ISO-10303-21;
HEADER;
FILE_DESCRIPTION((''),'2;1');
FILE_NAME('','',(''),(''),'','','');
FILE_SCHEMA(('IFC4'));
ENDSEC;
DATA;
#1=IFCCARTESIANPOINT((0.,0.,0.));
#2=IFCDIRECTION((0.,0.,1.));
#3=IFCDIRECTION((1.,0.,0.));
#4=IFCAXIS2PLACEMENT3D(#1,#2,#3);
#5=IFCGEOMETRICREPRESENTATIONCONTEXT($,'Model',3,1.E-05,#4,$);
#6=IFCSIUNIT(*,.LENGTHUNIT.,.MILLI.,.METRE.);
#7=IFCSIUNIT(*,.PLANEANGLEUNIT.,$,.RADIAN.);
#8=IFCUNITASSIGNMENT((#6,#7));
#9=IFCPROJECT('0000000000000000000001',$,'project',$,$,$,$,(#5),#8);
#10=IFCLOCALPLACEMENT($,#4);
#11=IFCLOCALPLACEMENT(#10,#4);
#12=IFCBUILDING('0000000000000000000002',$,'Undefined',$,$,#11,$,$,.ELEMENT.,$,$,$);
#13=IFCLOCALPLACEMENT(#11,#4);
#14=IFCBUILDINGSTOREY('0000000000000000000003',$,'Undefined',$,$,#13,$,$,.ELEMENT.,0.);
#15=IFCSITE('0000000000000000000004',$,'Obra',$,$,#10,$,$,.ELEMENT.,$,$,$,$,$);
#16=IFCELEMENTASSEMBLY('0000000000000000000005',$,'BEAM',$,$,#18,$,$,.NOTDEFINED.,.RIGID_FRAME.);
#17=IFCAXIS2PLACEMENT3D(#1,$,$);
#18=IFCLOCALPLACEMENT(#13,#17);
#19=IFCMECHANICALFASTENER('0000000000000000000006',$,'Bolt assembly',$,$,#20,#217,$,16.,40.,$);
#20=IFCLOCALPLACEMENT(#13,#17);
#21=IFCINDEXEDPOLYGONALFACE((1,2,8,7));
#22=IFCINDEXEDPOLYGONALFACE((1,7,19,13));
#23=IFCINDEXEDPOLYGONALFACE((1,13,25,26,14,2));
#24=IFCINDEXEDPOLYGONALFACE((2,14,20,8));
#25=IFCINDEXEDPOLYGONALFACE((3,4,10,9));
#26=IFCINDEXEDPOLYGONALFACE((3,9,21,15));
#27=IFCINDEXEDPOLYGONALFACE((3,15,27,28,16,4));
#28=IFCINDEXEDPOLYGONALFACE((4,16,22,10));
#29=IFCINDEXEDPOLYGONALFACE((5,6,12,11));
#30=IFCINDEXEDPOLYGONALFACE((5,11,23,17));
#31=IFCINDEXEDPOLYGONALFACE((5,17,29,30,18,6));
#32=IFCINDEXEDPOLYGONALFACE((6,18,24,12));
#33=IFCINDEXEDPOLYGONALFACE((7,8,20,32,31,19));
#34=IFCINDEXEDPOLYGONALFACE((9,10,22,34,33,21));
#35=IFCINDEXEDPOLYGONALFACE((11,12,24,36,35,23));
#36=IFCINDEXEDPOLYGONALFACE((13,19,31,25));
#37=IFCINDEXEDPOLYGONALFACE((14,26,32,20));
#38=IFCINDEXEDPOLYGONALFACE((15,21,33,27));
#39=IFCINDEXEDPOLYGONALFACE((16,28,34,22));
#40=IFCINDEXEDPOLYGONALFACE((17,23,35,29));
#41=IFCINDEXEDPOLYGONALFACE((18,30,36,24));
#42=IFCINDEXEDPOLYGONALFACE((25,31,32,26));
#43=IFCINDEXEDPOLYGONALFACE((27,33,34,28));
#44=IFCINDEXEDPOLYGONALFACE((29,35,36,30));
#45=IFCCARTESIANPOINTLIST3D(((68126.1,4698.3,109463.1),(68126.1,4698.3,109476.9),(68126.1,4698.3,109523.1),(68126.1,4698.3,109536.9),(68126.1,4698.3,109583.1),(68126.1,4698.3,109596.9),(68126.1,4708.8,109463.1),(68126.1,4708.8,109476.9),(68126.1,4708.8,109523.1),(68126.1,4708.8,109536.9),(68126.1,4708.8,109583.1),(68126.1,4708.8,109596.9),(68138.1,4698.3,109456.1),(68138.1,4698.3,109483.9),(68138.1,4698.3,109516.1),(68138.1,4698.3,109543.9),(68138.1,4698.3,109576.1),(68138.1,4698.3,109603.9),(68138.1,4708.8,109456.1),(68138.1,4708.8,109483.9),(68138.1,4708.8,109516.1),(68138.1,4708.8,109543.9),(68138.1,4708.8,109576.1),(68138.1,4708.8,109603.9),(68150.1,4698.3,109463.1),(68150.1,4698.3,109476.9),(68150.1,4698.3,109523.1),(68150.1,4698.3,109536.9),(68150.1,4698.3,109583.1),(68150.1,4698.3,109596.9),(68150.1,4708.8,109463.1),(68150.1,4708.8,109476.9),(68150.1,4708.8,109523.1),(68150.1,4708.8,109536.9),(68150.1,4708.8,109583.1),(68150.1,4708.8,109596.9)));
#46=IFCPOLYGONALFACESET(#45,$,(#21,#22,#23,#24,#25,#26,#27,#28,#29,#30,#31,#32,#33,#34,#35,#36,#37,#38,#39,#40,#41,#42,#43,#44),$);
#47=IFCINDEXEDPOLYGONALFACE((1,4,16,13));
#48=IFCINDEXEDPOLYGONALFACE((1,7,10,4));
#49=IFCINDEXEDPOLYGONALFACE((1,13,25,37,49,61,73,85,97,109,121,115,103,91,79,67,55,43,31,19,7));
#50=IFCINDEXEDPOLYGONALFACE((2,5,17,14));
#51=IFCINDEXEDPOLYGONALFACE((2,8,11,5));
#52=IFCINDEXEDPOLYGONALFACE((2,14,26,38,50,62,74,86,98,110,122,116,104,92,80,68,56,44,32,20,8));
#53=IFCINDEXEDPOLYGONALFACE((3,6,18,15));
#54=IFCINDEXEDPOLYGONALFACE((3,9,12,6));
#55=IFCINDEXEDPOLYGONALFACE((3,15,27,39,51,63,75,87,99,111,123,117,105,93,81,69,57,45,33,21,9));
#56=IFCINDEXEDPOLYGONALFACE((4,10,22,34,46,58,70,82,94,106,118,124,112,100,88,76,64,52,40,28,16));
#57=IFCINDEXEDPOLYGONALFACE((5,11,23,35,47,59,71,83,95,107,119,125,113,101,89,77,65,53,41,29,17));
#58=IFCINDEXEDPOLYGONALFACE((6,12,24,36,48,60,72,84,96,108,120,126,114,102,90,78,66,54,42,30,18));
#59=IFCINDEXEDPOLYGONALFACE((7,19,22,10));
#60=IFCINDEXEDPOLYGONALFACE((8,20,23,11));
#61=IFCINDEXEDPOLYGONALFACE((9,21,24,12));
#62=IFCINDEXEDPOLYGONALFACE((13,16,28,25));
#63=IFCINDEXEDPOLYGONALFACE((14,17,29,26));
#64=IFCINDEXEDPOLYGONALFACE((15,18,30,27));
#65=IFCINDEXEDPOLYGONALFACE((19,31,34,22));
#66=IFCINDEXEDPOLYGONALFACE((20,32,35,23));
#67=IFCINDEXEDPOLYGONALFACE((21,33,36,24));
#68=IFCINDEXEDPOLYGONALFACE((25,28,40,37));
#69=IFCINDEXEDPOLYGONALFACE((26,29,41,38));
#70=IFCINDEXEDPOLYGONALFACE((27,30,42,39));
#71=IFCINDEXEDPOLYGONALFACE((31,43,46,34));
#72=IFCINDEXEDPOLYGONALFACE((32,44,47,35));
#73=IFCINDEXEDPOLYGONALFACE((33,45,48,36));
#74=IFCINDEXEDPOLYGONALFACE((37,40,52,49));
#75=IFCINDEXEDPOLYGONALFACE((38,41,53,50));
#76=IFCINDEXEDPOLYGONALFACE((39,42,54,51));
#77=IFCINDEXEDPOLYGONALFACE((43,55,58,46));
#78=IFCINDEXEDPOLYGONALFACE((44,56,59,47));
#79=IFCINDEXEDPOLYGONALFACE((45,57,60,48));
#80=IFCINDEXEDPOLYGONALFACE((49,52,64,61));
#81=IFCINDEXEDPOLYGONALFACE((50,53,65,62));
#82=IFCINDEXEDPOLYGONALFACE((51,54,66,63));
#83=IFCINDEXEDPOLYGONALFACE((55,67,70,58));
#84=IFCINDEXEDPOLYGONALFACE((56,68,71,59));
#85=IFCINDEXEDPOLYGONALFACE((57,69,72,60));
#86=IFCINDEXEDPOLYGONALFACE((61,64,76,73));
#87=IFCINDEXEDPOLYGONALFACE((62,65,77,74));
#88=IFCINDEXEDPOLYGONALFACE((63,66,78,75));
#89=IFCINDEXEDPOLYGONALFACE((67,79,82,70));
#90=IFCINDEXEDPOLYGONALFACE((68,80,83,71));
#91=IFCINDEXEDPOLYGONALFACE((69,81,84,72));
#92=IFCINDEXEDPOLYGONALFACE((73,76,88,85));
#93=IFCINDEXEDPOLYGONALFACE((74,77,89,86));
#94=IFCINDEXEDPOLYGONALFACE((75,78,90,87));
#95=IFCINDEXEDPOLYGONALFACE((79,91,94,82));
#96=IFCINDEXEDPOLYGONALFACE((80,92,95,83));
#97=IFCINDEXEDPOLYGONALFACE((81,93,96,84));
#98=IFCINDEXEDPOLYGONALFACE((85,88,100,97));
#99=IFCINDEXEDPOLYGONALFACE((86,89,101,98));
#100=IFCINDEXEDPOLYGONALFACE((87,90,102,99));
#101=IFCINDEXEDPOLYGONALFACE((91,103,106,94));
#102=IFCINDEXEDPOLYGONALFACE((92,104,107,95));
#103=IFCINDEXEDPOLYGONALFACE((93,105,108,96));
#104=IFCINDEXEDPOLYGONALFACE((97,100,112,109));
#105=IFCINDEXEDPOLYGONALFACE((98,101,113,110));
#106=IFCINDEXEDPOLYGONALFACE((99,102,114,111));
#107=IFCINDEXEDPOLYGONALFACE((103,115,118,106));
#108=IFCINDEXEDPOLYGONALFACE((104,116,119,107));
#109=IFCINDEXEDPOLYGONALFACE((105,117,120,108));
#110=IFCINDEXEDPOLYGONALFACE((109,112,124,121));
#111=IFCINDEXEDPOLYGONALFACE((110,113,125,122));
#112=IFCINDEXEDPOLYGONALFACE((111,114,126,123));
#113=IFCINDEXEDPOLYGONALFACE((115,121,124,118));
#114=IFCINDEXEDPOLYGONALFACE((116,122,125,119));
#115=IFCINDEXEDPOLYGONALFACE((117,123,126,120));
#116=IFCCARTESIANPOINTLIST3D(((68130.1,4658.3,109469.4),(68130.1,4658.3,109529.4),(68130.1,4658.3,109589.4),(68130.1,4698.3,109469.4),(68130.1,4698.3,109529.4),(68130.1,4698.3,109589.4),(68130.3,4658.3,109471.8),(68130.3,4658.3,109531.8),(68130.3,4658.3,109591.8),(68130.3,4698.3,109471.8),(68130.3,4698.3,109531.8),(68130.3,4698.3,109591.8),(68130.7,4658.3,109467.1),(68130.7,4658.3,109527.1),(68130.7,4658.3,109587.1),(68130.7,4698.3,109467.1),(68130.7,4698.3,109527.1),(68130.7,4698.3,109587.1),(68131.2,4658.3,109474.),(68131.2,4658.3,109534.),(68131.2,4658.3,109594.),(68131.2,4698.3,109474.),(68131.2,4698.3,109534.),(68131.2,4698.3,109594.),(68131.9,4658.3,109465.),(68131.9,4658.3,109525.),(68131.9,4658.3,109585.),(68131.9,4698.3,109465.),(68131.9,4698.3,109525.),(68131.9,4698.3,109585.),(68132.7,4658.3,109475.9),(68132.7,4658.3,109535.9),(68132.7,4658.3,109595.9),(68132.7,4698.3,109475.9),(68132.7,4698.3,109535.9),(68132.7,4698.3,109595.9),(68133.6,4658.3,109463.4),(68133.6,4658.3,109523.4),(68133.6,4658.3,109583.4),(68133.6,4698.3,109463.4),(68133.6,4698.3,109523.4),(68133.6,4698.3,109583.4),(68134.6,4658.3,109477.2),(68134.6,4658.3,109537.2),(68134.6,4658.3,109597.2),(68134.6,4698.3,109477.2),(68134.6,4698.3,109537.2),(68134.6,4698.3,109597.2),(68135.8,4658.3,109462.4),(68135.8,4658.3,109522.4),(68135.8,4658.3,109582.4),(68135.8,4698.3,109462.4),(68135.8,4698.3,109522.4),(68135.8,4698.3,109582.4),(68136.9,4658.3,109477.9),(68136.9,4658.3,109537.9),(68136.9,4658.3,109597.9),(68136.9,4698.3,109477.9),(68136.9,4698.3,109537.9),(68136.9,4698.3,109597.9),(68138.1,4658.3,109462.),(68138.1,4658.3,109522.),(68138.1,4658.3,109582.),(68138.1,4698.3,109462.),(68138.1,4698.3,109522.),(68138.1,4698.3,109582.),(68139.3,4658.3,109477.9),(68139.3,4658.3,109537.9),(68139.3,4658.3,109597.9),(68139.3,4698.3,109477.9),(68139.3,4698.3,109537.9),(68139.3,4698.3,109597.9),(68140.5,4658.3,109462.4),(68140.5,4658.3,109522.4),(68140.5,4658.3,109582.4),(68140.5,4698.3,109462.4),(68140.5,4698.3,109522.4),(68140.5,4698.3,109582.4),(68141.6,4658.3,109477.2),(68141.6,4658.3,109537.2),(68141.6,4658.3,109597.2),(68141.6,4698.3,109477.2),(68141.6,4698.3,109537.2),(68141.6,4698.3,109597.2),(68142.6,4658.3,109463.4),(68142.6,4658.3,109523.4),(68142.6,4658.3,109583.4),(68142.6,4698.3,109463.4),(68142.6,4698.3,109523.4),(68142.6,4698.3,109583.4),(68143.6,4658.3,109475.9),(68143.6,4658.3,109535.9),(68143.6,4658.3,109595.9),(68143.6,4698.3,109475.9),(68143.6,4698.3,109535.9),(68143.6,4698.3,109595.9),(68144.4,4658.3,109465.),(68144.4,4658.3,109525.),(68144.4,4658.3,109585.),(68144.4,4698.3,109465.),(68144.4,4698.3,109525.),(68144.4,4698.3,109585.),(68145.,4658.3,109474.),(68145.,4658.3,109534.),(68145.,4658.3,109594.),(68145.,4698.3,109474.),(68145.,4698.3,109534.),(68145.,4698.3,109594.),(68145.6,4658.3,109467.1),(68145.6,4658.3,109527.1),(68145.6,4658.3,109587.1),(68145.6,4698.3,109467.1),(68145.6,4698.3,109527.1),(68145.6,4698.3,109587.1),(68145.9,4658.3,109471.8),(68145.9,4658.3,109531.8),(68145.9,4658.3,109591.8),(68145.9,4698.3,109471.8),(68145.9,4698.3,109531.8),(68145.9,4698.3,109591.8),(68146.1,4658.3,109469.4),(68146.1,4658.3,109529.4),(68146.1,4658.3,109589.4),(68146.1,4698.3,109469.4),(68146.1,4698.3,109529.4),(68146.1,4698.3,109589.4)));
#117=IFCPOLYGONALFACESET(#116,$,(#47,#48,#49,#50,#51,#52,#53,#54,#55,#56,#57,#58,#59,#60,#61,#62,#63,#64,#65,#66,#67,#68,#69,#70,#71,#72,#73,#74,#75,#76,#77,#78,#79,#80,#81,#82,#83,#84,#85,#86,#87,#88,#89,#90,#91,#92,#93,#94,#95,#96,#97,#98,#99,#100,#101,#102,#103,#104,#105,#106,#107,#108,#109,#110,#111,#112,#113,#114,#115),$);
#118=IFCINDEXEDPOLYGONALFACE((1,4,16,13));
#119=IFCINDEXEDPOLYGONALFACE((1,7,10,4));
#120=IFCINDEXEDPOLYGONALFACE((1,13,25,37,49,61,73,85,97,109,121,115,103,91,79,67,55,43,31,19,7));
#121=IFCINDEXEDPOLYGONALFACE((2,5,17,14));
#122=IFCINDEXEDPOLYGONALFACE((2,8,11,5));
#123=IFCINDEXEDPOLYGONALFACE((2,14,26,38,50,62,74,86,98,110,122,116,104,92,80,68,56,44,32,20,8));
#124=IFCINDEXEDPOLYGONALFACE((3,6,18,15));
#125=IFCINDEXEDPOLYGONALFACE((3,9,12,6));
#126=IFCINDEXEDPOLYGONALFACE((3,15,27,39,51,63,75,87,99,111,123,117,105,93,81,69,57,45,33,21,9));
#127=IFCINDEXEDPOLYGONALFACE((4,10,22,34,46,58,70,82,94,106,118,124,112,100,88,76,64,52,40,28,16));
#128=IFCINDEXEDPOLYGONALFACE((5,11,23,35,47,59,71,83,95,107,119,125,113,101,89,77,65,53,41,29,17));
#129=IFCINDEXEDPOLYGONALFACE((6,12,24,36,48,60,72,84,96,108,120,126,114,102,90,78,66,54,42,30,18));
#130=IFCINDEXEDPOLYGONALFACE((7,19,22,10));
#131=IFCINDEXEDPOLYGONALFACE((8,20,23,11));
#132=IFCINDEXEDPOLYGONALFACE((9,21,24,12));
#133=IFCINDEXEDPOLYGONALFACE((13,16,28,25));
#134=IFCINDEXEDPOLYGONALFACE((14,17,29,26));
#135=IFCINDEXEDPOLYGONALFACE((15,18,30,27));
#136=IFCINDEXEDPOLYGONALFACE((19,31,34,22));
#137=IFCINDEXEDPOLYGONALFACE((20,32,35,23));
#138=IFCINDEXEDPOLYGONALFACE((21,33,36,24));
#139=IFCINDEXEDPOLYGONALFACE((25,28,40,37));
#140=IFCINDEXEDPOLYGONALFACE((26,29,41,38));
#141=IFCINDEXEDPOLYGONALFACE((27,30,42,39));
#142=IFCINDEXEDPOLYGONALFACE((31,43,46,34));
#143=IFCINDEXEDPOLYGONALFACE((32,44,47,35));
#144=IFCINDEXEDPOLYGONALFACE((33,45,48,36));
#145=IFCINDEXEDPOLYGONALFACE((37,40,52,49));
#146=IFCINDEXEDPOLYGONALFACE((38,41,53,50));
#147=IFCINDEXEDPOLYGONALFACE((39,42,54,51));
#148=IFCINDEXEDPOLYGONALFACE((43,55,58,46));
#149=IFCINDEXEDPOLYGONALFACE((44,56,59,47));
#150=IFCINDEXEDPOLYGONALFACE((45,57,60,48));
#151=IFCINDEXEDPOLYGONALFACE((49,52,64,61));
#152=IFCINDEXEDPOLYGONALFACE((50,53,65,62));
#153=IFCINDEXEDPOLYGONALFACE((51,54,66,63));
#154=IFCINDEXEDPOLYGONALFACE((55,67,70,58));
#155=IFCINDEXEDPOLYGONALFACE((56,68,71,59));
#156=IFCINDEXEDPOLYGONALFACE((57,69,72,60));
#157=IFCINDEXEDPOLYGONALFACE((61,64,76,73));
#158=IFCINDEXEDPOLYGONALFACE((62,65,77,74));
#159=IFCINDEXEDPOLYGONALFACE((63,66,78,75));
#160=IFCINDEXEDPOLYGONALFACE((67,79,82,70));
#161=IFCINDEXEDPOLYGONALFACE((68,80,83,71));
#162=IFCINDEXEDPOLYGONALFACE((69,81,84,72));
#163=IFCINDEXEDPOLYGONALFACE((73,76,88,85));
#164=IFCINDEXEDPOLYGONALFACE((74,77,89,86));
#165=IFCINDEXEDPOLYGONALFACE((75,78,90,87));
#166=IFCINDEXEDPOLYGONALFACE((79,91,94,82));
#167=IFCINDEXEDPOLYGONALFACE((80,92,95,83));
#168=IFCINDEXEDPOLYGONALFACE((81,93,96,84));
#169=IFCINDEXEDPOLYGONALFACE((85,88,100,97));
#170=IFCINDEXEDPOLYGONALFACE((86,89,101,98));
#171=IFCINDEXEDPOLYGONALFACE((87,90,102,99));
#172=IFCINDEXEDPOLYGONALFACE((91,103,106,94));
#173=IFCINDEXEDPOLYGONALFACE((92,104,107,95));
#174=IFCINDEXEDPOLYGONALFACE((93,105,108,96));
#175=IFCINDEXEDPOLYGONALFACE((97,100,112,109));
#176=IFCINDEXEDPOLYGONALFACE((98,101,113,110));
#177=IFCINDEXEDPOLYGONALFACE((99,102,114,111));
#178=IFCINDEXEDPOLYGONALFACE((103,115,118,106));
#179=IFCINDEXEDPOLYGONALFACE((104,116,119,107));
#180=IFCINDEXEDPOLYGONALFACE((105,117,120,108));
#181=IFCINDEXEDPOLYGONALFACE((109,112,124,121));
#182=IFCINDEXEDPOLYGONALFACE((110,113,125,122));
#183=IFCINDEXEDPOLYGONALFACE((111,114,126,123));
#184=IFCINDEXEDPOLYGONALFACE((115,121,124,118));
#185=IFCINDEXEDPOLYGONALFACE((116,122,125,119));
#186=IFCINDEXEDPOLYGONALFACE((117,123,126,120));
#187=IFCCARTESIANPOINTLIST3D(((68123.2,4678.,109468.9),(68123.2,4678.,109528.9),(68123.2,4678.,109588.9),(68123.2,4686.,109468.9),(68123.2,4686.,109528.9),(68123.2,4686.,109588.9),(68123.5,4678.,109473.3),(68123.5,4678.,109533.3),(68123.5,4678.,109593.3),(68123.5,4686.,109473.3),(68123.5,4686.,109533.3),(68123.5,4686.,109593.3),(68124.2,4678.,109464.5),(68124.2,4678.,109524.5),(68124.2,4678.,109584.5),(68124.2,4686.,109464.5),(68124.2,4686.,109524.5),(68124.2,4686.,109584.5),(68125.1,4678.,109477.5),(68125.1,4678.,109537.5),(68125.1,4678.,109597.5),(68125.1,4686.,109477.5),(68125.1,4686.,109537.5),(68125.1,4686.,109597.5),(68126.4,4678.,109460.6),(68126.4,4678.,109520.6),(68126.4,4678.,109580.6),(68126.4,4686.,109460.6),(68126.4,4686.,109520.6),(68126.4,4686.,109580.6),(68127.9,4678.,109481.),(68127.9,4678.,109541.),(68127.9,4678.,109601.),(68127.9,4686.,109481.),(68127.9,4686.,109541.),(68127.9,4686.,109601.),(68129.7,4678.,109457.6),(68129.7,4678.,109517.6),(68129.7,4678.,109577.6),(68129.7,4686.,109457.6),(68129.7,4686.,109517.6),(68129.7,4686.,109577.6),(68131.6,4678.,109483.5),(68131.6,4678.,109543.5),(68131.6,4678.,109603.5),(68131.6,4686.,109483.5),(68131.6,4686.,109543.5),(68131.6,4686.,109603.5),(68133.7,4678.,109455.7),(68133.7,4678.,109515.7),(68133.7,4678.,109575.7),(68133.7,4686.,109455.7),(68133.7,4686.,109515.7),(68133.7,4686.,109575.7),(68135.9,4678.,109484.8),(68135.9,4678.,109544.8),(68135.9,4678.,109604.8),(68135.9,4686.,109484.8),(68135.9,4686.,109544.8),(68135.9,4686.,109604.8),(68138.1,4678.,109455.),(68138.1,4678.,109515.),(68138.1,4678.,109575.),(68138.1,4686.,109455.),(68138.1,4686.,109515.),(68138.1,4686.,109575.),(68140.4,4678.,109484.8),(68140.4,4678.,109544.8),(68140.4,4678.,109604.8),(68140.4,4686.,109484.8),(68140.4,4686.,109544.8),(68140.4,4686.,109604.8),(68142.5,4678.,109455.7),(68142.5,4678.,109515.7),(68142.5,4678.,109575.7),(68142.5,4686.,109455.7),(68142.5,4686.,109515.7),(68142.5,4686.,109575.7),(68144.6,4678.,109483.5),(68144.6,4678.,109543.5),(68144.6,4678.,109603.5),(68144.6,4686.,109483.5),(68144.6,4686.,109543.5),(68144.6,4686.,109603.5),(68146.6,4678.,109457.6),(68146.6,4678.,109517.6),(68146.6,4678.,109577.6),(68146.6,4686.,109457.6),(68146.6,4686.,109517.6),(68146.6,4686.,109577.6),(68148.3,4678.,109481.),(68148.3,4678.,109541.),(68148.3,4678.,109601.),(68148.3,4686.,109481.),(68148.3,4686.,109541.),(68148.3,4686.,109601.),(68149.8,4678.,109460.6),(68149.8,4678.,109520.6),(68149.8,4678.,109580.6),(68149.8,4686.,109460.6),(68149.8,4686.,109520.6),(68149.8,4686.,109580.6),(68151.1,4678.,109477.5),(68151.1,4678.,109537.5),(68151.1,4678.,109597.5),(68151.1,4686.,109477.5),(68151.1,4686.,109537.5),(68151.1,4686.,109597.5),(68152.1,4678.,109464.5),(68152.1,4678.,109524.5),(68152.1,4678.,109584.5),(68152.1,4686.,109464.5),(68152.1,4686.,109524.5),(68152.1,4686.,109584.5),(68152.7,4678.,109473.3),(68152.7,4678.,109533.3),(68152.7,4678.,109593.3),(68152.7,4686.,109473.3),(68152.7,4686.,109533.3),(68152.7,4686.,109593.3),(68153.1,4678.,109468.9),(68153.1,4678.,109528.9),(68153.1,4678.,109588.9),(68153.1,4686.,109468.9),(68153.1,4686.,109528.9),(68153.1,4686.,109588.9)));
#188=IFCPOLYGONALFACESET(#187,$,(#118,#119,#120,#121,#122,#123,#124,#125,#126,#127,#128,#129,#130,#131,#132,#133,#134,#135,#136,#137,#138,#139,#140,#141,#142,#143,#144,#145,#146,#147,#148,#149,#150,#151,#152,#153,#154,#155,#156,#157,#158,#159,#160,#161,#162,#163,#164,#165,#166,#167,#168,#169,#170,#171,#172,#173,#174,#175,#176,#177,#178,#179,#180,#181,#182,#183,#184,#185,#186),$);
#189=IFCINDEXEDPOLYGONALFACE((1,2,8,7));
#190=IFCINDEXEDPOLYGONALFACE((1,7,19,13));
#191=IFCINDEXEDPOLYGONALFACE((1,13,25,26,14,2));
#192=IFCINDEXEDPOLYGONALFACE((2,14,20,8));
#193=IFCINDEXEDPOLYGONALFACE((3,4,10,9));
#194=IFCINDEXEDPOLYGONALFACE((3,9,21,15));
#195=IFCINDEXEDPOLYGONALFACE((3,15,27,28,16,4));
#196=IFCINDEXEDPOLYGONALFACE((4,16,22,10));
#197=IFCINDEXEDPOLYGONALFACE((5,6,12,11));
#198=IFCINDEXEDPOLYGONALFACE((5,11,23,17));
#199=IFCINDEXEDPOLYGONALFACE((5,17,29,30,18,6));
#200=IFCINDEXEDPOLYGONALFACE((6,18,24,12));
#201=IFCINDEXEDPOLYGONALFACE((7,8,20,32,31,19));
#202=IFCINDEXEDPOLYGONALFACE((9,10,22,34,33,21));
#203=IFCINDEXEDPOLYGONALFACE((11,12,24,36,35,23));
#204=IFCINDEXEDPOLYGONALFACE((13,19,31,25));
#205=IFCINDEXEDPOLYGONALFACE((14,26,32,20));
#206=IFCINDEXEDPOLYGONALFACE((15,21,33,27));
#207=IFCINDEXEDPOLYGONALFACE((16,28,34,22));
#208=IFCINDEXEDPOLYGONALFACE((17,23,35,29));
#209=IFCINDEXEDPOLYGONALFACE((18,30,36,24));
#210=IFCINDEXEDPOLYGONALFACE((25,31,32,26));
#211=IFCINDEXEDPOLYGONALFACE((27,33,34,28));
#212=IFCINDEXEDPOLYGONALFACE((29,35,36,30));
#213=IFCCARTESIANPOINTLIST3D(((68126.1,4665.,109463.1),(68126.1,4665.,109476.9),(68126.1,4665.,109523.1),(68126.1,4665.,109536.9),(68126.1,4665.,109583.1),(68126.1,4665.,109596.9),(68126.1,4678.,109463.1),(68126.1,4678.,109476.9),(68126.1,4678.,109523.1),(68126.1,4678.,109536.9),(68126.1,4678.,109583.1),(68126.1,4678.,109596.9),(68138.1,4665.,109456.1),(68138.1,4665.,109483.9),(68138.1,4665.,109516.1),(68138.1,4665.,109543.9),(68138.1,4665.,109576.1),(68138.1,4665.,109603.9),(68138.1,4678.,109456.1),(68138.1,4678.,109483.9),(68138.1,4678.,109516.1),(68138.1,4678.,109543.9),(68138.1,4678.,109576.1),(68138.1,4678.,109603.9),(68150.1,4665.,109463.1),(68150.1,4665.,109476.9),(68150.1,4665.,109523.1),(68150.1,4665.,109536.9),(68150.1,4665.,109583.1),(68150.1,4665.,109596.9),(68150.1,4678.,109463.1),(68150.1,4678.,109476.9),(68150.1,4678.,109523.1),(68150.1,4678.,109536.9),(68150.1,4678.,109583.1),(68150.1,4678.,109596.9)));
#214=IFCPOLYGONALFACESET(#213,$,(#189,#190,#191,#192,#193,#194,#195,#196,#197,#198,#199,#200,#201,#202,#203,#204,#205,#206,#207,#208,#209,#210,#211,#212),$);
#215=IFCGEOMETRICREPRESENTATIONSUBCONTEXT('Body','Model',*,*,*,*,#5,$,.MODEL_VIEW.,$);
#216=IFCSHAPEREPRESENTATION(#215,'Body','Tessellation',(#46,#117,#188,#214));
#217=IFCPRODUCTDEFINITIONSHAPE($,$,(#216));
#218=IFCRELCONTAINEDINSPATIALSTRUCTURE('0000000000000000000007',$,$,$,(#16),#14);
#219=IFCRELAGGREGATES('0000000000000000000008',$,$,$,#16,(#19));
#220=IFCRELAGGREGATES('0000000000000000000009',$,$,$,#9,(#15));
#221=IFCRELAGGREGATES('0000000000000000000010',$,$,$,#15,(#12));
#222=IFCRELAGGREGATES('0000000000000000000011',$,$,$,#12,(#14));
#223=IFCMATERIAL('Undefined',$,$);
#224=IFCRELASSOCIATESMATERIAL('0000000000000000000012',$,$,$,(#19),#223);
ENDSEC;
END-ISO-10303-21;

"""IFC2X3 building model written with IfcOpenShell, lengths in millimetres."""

from ifc_helpers import new_model, si_unit, frame, origin_with_axes, origin_2d_with_axis, place, context, subcontext, project, spatial, polyline, circle, outline, extrude, source, transform, mapped, material, element, aggregate, save


model = new_model("IFC2X3")

# Units and contexts
model_context = context("Model", 3, precision=1e-05, world=origin_with_axes())
body_context = subcontext(model_context, "Body", "Model", "MODEL_VIEW")
ifc_project = project(units=[si_unit("LENGTHUNIT", "METRE", prefix="MILLI"), si_unit("PLANEANGLEUNIT", "RADIAN")], contexts=[model_context])

# Site, building, storey
site_placement = place(None, origin_with_axes())
site = spatial("IfcSite", under=ifc_project, at=site_placement, Name="Obra", CompositionType="ELEMENT")
building_placement = place(site_placement, origin_with_axes())
building = spatial("IfcBuilding", under=site, at=building_placement, Name="Undefined", CompositionType="ELEMENT")
storey_placement = place(building_placement, origin_with_axes())
storey = spatial("IfcBuildingStorey", under=building, at=storey_placement, Name="Undefined", CompositionType="ELEMENT", Elevation=0.0)

# Shared definitions
ifc_material_1 = material(Name="Undefined")

# Shared definitions
shared_shape_1 = source(origin_with_axes(), body_context, "Body", "SweptSolid", [
    extrude(outline(polyline([(13.9, 0.0), (6.9, 12.0), (-6.9, 12.0), (-13.9, 0.0), (-6.9, -12.0), (6.9, -12.0), (13.9, 0.0)])), frame((0.0, -19.7, 0.0), z_axis=(0.0, 1.0, 0.0), x_axis=(1.0, 0.0, 0.0)), (0.0, 0.0, 1.0), 10.6),
    extrude(circle(Radius=8.0, at=origin_2d_with_axis()), frame((0.0, -9.1, 0.0), z_axis=(0.0, 1.0, 0.0), x_axis=(1.0, 0.0, 0.0)), (0.0, 0.0, 1.0), 40.0),
    extrude(circle(Radius=15.0, at=origin_2d_with_axis()), frame((0.0, 3.1, 0.0), z_axis=(0.0, 1.0, 0.0), x_axis=(1.0, 0.0, 0.0)), (0.0, 0.0, 1.0), 8.0),
    extrude(outline(polyline([(13.9, 0.0), (6.9, 12.0), (-6.9, 12.0), (-13.9, 0.0), (-6.9, -12.0), (6.9, -12.0), (13.9, 0.0)])), frame((0.0, 11.1, 0.0), z_axis=(0.0, 1.0, 0.0), x_axis=(1.0, 0.0, 0.0)), (0.0, 0.0, 1.0), 13.0),
])

# Element assembly, mechanical fastener
assembly_1_placement = place(storey_placement, origin_with_axes())
assembly_1 = element("IfcElementAssembly", 1, at=assembly_1_placement, inside=storey, Name="BEAM", AssemblyPlace="NOTDEFINED", PredefinedType="RIGID_FRAME")
mechanical_fastener_1_placement = place(assembly_1_placement, frame((68188.1, 4689.2, 109650.0), z_axis=(-1.0, 0.000126, 0.0), x_axis=(0.0, 0.0, -1.0)))
mechanical_fastener_1 = element("IfcMechanicalFastener", 2, at=mechanical_fastener_1_placement, material=ifc_material_1, Name="Bolt assembly", NominalDiameter=16.0, NominalLength=40.0, context=body_context, shape_type="MappedRepresentation", body=[
    mapped(shared_shape_1, transform((60.0, 0.0, 50.0))),
    mapped(shared_shape_1, transform((120.0, 0.0, 50.0))),
    mapped(shared_shape_1, transform((180.0, 0.0, 50.0))),
])
aggregate(assembly_1, [mechanical_fastener_1])

save(model, "model.ifc")
